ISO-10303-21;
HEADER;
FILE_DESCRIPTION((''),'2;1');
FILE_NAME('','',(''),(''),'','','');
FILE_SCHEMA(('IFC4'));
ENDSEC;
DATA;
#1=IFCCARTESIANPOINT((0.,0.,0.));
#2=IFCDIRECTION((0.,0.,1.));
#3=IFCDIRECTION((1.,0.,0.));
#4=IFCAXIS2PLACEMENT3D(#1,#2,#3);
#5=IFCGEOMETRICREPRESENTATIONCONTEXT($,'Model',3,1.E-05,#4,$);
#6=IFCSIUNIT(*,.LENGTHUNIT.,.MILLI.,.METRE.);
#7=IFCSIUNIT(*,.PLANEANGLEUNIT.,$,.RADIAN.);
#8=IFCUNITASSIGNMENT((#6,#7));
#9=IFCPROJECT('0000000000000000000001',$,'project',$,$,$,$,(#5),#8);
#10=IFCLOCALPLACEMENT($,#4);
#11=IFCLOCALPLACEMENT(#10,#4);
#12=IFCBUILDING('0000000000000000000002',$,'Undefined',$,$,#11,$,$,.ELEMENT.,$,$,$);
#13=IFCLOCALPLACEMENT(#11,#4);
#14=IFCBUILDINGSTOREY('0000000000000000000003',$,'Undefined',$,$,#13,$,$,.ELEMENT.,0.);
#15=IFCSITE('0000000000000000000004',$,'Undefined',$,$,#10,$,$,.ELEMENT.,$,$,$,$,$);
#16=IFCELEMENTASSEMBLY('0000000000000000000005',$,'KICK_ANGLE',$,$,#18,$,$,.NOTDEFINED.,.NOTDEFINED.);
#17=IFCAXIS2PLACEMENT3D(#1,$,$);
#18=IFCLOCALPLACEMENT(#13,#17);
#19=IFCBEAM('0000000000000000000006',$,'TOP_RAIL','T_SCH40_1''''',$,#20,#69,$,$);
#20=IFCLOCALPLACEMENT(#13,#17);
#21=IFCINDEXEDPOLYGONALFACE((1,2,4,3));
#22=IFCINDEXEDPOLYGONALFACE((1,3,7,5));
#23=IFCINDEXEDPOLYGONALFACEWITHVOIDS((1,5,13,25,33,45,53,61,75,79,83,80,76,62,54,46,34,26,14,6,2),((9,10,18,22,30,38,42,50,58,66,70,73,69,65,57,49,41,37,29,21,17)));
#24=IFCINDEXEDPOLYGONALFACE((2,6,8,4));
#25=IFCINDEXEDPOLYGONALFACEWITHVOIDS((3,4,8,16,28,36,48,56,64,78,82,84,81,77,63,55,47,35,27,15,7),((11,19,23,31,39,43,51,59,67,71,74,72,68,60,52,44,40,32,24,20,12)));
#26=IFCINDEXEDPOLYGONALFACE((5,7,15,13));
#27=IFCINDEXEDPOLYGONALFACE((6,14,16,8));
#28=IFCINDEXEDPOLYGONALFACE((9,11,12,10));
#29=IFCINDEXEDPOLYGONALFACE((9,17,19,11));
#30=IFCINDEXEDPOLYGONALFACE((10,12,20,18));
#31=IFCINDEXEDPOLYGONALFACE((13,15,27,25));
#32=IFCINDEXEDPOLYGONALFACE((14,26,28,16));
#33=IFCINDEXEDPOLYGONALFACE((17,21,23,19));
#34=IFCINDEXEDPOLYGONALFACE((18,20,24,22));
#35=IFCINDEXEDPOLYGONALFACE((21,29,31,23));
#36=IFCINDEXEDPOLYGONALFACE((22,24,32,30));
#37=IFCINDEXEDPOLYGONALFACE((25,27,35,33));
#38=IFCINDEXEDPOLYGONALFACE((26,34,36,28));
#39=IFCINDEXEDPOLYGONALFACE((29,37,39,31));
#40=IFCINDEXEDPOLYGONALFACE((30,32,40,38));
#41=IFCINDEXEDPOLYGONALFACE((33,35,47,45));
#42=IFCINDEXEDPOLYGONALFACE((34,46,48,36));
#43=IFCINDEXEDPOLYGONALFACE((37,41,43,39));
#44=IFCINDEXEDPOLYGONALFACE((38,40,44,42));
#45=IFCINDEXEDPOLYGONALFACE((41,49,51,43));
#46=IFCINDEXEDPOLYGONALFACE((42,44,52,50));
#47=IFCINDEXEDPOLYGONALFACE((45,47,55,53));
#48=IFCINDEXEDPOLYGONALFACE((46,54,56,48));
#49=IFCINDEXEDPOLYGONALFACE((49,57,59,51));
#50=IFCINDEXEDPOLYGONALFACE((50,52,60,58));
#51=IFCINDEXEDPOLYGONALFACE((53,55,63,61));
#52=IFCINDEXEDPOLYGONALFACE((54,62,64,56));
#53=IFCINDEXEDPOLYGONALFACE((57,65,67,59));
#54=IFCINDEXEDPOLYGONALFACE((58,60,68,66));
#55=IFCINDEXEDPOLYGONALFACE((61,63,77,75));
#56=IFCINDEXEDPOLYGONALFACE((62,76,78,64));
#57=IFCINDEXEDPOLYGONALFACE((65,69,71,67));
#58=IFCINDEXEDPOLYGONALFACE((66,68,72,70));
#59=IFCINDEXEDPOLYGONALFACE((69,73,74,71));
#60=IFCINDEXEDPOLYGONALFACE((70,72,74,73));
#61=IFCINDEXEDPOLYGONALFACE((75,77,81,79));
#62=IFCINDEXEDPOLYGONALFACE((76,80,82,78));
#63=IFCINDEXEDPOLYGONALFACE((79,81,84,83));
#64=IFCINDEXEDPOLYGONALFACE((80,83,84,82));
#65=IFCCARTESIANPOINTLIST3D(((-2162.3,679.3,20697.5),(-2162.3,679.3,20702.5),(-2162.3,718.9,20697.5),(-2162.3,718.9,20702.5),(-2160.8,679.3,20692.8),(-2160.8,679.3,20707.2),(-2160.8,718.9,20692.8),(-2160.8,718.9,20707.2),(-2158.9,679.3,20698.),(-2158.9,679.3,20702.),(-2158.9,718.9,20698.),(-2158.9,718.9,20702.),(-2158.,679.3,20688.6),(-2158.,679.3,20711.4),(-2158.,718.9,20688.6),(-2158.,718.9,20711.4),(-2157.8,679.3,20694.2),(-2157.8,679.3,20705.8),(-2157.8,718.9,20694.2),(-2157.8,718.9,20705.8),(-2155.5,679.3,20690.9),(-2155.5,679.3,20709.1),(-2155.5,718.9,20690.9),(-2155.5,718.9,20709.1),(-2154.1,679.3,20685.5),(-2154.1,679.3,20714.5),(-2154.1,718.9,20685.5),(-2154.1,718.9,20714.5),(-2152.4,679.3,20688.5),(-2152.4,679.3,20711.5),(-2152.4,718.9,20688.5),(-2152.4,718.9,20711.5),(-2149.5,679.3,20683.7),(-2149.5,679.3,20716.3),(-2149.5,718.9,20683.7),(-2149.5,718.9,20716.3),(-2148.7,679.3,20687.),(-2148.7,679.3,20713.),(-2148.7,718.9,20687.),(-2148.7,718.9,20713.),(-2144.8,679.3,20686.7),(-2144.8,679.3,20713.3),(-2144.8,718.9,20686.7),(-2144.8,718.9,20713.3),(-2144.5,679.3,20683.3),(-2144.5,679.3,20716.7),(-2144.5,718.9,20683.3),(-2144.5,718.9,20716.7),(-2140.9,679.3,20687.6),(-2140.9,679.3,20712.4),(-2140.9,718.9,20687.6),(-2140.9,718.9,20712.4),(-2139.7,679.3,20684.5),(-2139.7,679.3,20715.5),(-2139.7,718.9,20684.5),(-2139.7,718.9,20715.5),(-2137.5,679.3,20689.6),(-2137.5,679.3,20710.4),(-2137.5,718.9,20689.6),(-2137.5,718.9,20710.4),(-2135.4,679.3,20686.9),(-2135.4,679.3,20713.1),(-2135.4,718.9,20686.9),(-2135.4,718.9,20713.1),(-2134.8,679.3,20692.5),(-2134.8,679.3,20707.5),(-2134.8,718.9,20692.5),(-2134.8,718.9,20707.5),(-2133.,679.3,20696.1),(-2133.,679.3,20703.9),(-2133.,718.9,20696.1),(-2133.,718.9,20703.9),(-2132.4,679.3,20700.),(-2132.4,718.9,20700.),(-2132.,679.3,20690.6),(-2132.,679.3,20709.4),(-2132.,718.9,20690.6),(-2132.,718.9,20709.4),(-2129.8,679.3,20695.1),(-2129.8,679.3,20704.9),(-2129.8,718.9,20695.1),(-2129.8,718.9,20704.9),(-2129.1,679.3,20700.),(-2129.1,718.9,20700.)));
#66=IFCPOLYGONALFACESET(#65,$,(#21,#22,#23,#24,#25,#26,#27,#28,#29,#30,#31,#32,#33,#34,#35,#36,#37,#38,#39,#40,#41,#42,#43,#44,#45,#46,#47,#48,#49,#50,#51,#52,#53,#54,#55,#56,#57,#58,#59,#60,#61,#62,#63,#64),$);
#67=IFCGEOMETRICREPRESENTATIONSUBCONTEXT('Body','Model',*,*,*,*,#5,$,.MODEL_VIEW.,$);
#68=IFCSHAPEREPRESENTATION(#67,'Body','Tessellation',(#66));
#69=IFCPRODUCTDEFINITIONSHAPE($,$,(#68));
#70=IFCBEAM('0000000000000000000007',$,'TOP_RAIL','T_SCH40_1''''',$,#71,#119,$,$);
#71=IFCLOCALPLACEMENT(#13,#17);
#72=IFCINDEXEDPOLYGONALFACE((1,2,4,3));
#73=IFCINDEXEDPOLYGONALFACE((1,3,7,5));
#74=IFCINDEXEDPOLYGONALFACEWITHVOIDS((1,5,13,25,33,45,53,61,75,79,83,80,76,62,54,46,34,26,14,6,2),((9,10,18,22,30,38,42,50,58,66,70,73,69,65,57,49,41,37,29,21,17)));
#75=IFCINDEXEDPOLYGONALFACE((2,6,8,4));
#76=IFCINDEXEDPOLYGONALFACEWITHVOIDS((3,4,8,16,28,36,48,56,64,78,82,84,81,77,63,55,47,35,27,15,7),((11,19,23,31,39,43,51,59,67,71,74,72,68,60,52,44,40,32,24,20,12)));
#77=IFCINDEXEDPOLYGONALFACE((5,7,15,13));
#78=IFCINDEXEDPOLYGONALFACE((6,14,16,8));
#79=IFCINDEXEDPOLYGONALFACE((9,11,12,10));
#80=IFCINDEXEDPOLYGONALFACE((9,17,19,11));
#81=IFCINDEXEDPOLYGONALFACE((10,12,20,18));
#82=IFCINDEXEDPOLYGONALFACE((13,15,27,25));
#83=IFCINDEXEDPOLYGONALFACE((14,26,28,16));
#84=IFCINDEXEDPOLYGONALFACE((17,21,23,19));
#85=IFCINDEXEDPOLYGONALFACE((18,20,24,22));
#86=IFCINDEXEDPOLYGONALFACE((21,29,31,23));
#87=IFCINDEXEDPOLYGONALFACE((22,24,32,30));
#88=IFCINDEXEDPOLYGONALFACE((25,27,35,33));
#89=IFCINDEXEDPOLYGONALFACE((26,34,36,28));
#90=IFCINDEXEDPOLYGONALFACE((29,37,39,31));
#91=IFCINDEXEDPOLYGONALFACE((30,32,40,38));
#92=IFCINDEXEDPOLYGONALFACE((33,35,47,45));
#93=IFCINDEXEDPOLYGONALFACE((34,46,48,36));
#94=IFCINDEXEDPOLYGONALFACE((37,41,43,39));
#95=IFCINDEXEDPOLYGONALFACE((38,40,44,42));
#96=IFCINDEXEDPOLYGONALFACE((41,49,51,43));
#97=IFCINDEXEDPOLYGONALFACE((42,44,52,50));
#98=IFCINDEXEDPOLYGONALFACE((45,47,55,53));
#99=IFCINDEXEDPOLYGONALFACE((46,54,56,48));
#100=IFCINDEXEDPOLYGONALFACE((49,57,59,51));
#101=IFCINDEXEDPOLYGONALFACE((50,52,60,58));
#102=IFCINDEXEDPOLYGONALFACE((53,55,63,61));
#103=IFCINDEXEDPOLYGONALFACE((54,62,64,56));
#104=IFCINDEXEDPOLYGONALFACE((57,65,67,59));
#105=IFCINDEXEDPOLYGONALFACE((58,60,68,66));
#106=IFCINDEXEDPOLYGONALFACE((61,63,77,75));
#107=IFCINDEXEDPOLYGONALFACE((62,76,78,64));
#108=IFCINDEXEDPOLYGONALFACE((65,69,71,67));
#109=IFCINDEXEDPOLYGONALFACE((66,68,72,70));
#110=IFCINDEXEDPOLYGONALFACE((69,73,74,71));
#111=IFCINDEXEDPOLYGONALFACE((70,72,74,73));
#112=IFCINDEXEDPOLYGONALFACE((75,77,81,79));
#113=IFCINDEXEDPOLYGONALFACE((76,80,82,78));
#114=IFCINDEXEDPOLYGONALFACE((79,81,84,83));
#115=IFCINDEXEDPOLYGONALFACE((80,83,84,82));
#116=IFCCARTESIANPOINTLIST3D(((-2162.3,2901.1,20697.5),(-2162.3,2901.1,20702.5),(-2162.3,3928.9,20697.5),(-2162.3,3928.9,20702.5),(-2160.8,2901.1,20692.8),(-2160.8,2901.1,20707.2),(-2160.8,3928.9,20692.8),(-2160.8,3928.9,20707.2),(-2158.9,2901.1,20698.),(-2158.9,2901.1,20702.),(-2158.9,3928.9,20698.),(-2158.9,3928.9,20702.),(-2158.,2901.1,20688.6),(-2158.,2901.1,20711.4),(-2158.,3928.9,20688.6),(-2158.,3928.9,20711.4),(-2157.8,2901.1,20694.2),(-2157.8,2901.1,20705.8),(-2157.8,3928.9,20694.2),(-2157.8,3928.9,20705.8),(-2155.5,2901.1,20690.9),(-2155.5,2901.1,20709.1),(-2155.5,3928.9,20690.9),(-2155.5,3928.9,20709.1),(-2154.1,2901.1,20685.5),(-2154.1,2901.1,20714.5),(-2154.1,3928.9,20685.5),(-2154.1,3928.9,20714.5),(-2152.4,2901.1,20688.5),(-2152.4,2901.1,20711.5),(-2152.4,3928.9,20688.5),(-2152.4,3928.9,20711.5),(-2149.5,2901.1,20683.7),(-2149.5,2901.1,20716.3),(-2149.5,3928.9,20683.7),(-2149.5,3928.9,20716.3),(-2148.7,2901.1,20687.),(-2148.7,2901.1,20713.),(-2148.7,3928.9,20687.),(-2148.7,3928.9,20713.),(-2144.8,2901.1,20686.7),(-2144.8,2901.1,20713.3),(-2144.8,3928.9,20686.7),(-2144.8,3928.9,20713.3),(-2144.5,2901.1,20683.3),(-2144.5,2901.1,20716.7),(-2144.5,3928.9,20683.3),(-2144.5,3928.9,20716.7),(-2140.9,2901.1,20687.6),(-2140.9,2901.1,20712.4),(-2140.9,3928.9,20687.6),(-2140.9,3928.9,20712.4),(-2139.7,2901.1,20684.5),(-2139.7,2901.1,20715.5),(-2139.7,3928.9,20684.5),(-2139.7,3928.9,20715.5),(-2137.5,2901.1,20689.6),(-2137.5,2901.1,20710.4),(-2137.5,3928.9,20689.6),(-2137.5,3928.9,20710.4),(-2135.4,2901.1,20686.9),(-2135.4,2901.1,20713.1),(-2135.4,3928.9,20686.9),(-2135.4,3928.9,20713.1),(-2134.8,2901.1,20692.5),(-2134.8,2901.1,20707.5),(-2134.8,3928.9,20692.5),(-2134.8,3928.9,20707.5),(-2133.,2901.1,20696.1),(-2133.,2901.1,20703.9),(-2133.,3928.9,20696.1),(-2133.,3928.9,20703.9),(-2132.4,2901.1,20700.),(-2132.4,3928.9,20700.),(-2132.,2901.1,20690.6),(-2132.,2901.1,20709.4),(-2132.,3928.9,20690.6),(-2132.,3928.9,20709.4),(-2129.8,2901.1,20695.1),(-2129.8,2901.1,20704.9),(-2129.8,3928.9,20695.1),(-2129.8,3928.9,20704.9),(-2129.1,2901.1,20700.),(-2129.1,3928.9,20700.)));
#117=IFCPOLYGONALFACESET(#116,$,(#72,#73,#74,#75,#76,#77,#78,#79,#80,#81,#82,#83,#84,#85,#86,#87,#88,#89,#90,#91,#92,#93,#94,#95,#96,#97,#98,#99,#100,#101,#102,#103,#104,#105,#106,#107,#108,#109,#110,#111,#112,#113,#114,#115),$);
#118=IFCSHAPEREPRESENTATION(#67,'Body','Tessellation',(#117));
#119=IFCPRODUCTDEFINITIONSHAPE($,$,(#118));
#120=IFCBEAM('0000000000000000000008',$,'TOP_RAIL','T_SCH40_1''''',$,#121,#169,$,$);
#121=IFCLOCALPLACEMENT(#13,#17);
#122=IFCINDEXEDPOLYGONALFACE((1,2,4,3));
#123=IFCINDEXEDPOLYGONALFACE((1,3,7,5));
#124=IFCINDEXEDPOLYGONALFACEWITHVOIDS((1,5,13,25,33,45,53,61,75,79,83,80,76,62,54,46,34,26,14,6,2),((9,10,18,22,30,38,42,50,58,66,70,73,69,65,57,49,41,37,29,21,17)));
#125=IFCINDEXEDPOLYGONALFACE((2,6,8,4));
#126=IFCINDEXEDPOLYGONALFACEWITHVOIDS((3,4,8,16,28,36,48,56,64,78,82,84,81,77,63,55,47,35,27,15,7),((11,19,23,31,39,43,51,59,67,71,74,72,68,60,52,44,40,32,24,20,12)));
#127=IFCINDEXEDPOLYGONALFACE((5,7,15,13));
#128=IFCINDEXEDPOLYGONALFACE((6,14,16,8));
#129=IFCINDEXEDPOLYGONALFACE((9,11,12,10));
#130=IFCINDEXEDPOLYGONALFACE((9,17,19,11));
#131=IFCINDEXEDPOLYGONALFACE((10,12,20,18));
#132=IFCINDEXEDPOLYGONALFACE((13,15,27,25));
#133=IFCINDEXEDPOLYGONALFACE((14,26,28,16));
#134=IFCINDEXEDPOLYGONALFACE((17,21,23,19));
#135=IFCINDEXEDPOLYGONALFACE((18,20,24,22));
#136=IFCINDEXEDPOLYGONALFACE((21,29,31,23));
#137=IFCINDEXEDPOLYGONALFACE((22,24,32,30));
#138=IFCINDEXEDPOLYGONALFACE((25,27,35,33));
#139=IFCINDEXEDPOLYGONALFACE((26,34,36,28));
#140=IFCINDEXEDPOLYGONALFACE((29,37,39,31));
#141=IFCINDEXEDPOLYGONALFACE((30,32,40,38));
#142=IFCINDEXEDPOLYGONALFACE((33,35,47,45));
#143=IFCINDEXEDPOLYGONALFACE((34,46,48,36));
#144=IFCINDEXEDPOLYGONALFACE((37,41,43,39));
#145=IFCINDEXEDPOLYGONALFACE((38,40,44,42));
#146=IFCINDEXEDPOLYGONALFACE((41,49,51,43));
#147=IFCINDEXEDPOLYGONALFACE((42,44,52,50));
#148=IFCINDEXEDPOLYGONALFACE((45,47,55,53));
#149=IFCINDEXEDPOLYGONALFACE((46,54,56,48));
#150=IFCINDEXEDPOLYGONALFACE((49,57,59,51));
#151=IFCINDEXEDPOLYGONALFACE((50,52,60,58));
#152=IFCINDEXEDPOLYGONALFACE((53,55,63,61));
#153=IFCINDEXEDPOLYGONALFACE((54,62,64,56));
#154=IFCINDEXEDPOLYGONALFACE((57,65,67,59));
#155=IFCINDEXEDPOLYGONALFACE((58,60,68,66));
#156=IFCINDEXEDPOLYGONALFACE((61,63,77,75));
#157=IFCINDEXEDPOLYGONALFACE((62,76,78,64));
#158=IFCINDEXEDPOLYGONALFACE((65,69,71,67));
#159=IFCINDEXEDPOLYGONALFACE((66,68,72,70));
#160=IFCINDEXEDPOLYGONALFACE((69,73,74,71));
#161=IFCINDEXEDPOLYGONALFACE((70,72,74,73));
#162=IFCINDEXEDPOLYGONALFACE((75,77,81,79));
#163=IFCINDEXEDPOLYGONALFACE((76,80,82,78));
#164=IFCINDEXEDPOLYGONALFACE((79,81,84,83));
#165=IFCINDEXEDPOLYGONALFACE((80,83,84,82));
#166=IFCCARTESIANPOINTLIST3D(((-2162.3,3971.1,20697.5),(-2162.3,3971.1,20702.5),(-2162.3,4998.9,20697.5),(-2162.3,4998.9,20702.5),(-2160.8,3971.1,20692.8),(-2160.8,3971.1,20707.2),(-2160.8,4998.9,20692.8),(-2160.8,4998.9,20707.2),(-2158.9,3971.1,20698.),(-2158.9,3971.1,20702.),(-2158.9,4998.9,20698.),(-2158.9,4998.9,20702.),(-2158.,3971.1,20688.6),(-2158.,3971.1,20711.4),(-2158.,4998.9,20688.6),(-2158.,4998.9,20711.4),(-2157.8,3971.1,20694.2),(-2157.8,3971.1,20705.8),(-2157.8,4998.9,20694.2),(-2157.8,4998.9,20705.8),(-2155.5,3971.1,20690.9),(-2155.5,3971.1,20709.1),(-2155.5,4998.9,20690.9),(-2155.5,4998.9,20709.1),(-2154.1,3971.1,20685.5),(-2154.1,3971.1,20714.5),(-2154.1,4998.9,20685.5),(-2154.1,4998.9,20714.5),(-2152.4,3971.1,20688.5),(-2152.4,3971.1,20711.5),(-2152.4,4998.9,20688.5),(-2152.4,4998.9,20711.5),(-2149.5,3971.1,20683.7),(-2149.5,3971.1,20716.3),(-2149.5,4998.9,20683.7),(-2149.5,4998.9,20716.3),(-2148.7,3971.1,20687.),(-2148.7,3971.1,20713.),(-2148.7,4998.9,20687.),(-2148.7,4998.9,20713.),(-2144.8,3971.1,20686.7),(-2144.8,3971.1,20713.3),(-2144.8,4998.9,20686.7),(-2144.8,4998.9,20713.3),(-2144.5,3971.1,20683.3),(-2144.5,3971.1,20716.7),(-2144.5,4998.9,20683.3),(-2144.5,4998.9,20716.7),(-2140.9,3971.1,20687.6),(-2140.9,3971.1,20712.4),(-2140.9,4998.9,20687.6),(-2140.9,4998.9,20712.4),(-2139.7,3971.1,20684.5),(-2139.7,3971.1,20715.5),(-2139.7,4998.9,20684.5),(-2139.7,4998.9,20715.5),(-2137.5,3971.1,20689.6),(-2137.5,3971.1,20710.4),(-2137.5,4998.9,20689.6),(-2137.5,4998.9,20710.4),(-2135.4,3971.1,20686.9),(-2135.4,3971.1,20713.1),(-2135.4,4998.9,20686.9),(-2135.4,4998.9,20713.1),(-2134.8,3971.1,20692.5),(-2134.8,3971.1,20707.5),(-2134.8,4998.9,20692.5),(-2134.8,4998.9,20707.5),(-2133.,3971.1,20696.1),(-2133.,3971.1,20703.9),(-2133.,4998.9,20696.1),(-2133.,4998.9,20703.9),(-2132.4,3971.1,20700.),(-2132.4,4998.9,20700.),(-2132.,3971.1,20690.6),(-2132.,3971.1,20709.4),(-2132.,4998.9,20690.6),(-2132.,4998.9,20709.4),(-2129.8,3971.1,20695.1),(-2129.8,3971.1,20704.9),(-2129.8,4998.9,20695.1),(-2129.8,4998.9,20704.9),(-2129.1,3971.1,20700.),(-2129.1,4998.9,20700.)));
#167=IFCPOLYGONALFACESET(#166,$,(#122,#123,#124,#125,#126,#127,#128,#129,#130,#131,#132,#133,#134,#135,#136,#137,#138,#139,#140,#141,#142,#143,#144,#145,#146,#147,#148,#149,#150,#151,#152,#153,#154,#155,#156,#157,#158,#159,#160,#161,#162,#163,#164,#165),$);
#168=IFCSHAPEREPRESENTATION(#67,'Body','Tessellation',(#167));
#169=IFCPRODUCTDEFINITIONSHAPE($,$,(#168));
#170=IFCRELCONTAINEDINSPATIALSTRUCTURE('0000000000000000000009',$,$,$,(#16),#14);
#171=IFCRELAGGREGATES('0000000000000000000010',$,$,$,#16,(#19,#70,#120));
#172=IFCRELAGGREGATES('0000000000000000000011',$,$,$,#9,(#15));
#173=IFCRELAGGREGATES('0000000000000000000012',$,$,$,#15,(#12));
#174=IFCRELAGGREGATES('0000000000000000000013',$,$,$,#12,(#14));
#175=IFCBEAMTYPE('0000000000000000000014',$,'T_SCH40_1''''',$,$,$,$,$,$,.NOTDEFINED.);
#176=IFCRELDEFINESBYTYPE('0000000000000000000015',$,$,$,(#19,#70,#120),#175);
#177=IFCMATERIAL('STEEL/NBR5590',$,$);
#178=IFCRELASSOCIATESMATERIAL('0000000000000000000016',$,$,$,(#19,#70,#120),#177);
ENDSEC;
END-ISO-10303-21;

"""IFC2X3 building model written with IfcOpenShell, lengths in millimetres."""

from ifc_helpers import new_model, si_unit, frame, origin_with_axes, origin_2d_with_axis, place, context, subcontext, project, spatial, hollow_circle, extrude, clip, halfspace, material, type_object, element, aggregate, save


model = new_model("IFC2X3")

# Units and contexts
model_context = context("Model", 3, precision=1e-05, world=origin_with_axes())
body_context = subcontext(model_context, "Body", "Model", "MODEL_VIEW")
ifc_project = project(units=[si_unit("LENGTHUNIT", "METRE", prefix="MILLI"), si_unit("PLANEANGLEUNIT", "RADIAN")], contexts=[model_context])

# Site, building, storey
site_placement = place(None, origin_with_axes())
site = spatial("IfcSite", under=ifc_project, at=site_placement, Name="Undefined", CompositionType="ELEMENT")
building_placement = place(site_placement, origin_with_axes())
building = spatial("IfcBuilding", under=site, at=building_placement, Name="Undefined", CompositionType="ELEMENT")
storey_placement = place(building_placement, origin_with_axes())
storey = spatial("IfcBuildingStorey", under=building, at=storey_placement, Name="Undefined", CompositionType="ELEMENT", Elevation=0.0)

# Element assembly
assembly_1_placement = place(storey_placement, origin_with_axes())
assembly_1 = element("IfcElementAssembly", 1, at=assembly_1_placement, inside=storey, Name="KICK_ANGLE", AssemblyPlace="NOTDEFINED", PredefinedType="NOTDEFINED")
ifc_material_1 = material(Name="STEEL/NBR5590")

# Beams
beam_type_1 = type_object("IfcBeamType", Name="T_SCH40_1''", PredefinedType="NOTDEFINED")
beam_1_placement = place(assembly_1_placement, frame((-2145.8, 690.0, 20700.0), z_axis=(0.0, 0.0, 1.0), x_axis=(0.0, 1.0, 0.0)))
beam_1 = element("IfcBeam", 2, at=beam_1_placement, type_object=beam_type_1, material=ifc_material_1, Name="TOP_RAIL", Description="T_SCH40_1''", context=body_context, shape_type="Clipping", body=[
    clip(extrude(hollow_circle(Radius=16.7, WallThickness=3.4, at=origin_2d_with_axis()), frame((28.9, 0.0, 0.0), z_axis=(-1.0, 0.0, 0.0), x_axis=(0.0, -1.0, 0.0)), (0.0, 0.0, 1.0), 39.6), halfspace(frame((-10.7, 0.0, 0.0), z_axis=(1.0, 0.0, 0.0), x_axis=(0.0, -1.0, 0.0)), True)),
])
beam_2_placement = place(assembly_1_placement, frame((-2145.8, 2901.1, 20700.0), z_axis=(0.0, 0.0, 1.0), x_axis=(0.0, 1.0, 0.0)))
beam_2 = element("IfcBeam", 3, at=beam_2_placement, type_object=beam_type_1, material=ifc_material_1, Name="TOP_RAIL", Description="T_SCH40_1''", context=body_context, shape_type="SweptSolid", body=[
    extrude(hollow_circle(Radius=16.7, WallThickness=3.4, at=origin_2d_with_axis()), frame((1027.8, 0.0, 0.0), z_axis=(-1.0, 0.0, 0.0), x_axis=(0.0, -1.0, 0.0)), (0.0, 0.0, 1.0), 1027.8),
])
beam_3_placement = place(assembly_1_placement, frame((-2145.8, 3971.1, 20700.0), z_axis=(0.0, 0.0, 1.0), x_axis=(0.0, 1.0, 0.0)))
beam_3 = element("IfcBeam", 4, at=beam_3_placement, type_object=beam_type_1, material=ifc_material_1, Name="TOP_RAIL", Description="T_SCH40_1''", context=body_context, shape_type="SweptSolid", body=[
    extrude(hollow_circle(Radius=16.7, WallThickness=3.4, at=origin_2d_with_axis()), frame((1027.8, 0.0, 0.0), z_axis=(-1.0, 0.0, 0.0), x_axis=(0.0, -1.0, 0.0)), (0.0, 0.0, 1.0), 1027.8),
])

aggregate(assembly_1, [beam_1, beam_2, beam_3])

save(model, "model.ifc")
